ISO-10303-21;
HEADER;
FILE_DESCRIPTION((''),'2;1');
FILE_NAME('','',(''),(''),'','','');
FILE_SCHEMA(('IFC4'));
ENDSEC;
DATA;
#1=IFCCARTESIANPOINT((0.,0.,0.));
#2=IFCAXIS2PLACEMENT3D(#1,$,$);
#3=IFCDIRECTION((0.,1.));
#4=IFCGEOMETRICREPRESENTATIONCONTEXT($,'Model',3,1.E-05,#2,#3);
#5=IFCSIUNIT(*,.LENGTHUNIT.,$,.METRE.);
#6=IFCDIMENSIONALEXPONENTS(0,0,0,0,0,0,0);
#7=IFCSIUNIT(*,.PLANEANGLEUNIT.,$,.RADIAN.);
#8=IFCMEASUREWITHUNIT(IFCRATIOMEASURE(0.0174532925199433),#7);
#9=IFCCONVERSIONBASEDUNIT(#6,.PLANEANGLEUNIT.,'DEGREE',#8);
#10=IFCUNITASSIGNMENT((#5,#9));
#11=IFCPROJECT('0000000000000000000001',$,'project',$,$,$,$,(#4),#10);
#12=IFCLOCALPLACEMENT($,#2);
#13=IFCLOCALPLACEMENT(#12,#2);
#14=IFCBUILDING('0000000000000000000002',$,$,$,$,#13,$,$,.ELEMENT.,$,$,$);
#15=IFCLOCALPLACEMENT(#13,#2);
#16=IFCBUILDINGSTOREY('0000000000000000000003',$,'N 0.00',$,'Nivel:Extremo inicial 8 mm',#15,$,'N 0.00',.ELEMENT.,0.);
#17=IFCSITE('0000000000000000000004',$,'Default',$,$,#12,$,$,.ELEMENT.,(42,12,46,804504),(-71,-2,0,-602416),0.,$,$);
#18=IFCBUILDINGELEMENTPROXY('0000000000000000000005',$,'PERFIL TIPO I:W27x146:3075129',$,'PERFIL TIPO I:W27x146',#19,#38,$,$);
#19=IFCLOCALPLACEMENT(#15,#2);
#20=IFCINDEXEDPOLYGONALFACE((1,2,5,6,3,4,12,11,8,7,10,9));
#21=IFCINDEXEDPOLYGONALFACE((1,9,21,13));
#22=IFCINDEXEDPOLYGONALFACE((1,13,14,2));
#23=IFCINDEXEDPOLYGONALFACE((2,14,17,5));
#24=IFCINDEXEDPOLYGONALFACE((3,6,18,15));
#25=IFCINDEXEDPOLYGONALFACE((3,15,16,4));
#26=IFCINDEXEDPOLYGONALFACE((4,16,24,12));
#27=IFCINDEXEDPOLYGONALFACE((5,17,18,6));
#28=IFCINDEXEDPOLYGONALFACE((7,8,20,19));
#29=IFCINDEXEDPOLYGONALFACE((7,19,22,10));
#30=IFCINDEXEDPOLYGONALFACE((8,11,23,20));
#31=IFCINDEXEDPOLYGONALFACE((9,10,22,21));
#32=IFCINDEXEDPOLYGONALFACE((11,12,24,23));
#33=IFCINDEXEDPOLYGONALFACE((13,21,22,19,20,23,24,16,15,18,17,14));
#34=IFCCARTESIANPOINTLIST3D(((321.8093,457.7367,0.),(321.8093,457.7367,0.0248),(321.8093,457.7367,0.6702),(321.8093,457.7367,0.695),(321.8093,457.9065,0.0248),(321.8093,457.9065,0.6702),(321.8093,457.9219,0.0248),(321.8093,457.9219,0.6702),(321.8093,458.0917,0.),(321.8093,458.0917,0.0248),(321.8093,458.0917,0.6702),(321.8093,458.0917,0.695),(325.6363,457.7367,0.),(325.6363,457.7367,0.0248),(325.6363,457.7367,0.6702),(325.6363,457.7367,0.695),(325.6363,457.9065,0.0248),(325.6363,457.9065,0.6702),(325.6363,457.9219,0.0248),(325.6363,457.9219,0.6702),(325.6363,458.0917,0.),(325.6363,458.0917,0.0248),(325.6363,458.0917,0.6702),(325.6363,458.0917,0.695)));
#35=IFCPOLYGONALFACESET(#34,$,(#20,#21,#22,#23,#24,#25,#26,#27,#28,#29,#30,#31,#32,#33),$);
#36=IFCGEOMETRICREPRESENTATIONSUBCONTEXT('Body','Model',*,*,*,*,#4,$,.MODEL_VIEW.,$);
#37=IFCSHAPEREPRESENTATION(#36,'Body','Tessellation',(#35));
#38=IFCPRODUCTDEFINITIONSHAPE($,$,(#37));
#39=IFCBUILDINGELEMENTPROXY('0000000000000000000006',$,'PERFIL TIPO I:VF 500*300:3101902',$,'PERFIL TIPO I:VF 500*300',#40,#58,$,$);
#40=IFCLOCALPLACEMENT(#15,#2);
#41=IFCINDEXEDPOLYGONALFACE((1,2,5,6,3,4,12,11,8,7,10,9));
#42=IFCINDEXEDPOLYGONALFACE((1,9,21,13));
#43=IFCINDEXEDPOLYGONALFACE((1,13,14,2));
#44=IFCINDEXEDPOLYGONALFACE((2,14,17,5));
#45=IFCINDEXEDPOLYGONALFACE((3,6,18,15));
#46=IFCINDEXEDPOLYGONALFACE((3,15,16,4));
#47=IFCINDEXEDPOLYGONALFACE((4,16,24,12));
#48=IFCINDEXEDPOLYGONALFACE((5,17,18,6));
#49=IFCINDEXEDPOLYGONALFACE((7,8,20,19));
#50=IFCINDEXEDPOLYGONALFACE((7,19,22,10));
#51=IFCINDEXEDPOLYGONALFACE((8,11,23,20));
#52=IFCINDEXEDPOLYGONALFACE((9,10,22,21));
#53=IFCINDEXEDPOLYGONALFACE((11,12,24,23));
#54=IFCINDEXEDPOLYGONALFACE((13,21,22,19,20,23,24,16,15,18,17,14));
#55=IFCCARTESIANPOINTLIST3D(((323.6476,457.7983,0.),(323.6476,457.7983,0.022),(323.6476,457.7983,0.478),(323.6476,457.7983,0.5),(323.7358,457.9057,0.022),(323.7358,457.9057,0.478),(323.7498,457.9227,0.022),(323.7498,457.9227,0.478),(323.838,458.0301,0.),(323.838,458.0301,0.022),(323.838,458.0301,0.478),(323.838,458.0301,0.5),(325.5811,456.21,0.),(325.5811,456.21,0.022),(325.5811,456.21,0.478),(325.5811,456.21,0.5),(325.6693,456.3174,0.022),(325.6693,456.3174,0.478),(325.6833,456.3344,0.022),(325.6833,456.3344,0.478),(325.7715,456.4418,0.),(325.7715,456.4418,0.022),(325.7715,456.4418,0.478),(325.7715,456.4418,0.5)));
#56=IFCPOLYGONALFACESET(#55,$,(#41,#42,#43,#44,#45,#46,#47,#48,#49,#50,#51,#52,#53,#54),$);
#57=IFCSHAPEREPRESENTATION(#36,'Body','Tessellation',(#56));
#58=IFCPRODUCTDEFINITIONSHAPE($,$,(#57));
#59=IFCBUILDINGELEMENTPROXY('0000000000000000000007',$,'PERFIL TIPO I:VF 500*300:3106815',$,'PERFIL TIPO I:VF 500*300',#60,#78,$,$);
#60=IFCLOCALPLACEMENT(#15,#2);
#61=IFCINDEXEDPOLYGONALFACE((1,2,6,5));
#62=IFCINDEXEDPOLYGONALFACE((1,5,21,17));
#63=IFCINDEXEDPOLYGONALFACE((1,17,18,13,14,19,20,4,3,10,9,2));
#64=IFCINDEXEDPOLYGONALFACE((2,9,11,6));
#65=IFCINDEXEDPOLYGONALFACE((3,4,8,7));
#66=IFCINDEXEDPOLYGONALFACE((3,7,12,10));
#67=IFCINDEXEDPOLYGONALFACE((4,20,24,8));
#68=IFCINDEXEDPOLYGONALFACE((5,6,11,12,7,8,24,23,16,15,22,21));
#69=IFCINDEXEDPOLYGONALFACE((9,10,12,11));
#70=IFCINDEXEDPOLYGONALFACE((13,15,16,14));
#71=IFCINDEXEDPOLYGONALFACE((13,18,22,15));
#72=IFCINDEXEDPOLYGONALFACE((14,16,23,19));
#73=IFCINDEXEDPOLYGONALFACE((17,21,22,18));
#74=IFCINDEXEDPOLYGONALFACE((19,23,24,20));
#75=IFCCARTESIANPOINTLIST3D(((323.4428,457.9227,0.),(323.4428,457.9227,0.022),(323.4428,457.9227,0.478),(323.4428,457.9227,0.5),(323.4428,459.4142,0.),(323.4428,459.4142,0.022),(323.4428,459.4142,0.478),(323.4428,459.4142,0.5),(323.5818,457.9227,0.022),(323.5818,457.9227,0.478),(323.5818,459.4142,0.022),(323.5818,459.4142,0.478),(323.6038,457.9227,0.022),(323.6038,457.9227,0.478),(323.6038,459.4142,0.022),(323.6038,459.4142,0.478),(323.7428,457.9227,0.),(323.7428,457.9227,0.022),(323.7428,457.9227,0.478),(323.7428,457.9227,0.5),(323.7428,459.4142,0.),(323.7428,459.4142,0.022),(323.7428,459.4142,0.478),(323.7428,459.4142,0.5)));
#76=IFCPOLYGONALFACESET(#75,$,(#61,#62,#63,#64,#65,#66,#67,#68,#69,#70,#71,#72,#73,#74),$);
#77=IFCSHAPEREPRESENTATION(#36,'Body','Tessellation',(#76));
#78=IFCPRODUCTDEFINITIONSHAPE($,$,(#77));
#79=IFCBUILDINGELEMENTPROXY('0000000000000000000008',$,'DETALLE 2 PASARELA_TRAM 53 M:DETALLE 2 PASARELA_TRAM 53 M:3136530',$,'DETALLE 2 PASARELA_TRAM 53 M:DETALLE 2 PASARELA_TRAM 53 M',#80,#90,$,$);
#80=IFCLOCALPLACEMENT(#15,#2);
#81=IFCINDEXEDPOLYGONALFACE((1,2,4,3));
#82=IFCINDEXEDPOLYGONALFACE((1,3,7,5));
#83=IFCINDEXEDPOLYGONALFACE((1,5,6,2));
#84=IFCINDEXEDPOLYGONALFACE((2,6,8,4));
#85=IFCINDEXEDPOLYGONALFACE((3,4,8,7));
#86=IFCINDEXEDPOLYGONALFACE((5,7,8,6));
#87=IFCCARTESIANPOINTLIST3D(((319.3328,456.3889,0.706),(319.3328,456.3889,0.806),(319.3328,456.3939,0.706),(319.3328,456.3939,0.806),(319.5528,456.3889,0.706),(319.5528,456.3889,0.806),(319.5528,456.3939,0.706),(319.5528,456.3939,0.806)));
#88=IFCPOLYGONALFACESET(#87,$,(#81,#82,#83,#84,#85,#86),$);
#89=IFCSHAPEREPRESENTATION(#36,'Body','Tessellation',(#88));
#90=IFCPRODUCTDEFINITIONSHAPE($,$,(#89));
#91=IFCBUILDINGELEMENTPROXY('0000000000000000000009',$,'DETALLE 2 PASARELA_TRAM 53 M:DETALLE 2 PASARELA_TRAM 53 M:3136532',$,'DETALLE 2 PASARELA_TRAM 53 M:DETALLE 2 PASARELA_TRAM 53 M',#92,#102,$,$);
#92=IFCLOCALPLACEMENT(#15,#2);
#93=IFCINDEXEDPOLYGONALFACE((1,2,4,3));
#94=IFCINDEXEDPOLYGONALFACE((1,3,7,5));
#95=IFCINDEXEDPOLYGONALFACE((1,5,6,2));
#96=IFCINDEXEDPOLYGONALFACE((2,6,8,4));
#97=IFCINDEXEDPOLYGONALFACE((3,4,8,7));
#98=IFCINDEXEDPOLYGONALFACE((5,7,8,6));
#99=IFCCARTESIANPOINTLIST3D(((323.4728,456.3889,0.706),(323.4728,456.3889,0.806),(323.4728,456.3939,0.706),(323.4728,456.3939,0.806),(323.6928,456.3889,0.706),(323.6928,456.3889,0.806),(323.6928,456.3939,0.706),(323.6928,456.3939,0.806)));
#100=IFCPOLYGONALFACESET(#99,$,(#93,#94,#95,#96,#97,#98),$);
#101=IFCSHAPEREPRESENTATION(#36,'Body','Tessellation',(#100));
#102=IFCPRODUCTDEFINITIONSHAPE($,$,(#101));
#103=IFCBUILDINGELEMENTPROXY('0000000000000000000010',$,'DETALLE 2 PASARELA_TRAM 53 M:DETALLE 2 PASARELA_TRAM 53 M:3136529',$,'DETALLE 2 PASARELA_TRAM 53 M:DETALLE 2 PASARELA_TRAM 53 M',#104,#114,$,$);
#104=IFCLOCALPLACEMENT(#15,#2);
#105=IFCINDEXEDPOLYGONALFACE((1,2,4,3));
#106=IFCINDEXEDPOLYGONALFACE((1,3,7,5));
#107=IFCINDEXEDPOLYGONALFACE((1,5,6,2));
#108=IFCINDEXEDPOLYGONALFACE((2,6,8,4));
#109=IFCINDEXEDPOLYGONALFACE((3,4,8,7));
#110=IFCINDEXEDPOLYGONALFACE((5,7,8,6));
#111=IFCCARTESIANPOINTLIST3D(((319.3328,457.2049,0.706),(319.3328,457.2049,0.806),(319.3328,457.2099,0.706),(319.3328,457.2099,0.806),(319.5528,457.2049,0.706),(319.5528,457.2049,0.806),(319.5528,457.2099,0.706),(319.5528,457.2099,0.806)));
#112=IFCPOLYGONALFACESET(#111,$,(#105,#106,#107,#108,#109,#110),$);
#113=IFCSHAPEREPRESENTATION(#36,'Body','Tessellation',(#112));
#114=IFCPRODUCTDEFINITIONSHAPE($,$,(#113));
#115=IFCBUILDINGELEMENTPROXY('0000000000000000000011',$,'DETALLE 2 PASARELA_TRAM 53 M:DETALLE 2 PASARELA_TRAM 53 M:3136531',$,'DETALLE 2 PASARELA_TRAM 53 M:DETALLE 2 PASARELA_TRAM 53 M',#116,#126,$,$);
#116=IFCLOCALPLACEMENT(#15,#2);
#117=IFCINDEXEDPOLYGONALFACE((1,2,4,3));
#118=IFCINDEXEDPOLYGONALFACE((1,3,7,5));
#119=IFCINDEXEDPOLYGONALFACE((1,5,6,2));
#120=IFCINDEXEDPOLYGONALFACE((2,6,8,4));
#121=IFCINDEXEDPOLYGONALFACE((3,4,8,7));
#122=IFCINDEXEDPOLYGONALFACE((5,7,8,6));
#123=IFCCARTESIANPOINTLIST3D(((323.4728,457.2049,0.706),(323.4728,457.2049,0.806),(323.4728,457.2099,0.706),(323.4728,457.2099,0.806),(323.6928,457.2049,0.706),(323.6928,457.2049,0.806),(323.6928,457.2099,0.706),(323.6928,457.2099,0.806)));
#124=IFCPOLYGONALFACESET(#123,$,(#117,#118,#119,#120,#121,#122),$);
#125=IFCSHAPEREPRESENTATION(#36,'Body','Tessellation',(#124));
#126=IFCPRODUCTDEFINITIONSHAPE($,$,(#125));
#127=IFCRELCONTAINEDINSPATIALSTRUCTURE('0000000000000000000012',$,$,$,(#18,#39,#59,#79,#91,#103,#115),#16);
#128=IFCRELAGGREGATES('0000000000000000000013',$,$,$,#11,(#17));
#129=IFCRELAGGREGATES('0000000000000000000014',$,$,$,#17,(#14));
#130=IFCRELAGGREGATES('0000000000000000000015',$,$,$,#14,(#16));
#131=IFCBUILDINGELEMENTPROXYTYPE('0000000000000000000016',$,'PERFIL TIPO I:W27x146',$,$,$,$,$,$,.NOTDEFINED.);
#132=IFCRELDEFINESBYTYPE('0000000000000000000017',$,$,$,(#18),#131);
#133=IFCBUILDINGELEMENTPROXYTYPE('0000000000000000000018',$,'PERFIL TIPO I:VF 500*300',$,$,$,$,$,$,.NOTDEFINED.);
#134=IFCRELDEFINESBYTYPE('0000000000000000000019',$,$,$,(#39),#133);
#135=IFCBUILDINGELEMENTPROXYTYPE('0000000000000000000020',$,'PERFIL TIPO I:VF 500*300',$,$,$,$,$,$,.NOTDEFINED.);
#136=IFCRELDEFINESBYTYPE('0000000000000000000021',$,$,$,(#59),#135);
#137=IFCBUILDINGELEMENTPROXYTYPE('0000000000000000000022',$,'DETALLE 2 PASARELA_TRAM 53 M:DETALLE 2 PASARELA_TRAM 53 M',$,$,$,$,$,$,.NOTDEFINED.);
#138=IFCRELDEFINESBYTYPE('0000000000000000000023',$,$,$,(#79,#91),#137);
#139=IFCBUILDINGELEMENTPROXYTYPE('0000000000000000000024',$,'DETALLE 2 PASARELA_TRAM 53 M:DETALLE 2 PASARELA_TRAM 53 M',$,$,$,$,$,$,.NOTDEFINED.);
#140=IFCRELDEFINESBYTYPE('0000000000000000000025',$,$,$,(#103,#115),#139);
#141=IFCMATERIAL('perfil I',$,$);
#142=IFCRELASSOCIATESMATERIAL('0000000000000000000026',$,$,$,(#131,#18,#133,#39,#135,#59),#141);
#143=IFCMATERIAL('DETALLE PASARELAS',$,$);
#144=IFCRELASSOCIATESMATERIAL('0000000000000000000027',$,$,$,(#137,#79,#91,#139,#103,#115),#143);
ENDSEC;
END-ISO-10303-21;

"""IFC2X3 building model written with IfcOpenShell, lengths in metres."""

from ifc_helpers import new_model, entity, si_unit, converted_unit, direction, frame, frame_2d, origin, place, context, subcontext, project, spatial, polyline, rectangle, outline, extrude, source, transform, mapped, material, type_object, type_shapes, element, save


model = new_model("IFC2X3")

# Units and contexts
model_context = context("Model", 3, precision=1e-05, world=origin(), true_north=direction((0.0, 1.0)))
body_context = subcontext(model_context, "Body", "Model", "MODEL_VIEW")
ifc_project = project(units=[si_unit("LENGTHUNIT", "METRE"), converted_unit("PLANEANGLEUNIT", "DEGREE", entity("IfcRatioMeasure", 0.0174532925199433), si_unit("PLANEANGLEUNIT", "RADIAN"), dimensions=[0, 0, 0, 0, 0, 0, 0])], contexts=[model_context])

# Site, building, storey
site_placement = place(None, origin())
site = spatial("IfcSite", under=ifc_project, at=site_placement, Name="Default", CompositionType="ELEMENT", RefLatitude=(42, 12, 46, 804504), RefLongitude=(-71, -2, 0, -602416), RefElevation=0.0)
building_placement = place(site_placement, origin())
building = spatial("IfcBuilding", under=site, at=building_placement, CompositionType="ELEMENT")
storey_placement = place(building_placement, origin())
storey = spatial("IfcBuildingStorey", under=building, at=storey_placement, Name="N 0.00", ObjectType="Nivel:Extremo inicial 8 mm", LongName="N 0.00", CompositionType="ELEMENT", Elevation=0.0)

# Building element proxies
ifc_material_1 = material(Name="perfil I")
building_element_proxy_type_1 = type_object("IfcBuildingElementProxyType", Name="PERFIL TIPO I:W27x146", PredefinedType="NOTDEFINED", material=ifc_material_1)
shared_shape_1 = source(origin(), body_context, "Body", "SweptSolid", [
    extrude(outline(polyline([(0.3227, -0.1775), (0.3475, -0.1775), (0.3475, 0.1775), (0.3227, 0.1775), (0.3227, 0.0077), (-0.3227, 0.0077), (-0.3227, 0.1775), (-0.3475, 0.1775), (-0.3475, -0.1775), (-0.3227, -0.1775), (-0.3227, -0.0077), (0.3227, -0.0077), (0.3227, -0.1775)])), frame((0.0, 0.0, 0.3475), z_axis=(1.0, 0.0, 0.0), x_axis=(0.0, 0.0, 1.0)), (0.0, 0.0, 1.0), 3.827),
])
type_shapes(building_element_proxy_type_1, [shared_shape_1])
proxy_1_placement = place(storey_placement, frame((321.8093, 457.9142, 0.0)))
element("IfcBuildingElementProxy", 1, at=proxy_1_placement, inside=storey, type_object=building_element_proxy_type_1, material=ifc_material_1, Name="PERFIL TIPO I:W27x146:3075129", ObjectType="PERFIL TIPO I:W27x146", context=body_context, shape_type="MappedRepresentation", body=[
    mapped(shared_shape_1, transform((0.0, 0.0, 0.0), scale=1.0)),
])
building_element_proxy_type_2 = type_object("IfcBuildingElementProxyType", Name="PERFIL TIPO I:VF 500*300", PredefinedType="NOTDEFINED", material=ifc_material_1)
shared_shape_2 = source(origin(), body_context, "Body", "SweptSolid", [
    extrude(outline(polyline([(-0.15, -0.228), (-0.15, -0.25), (0.15, -0.25), (0.15, -0.228), (0.011, -0.228), (0.011, 0.228), (0.15, 0.228), (0.15, 0.25), (-0.15, 0.25), (-0.15, 0.228), (-0.011, 0.228), (-0.011, -0.228), (-0.15, -0.228)])), frame((0.0, 0.0, 0.25), z_axis=(-1.0, 0.0, 0.0), x_axis=(0.0, 1.0, 0.0)), (0.0, 0.0, -1.0), 2.5022),
])
type_shapes(building_element_proxy_type_2, [shared_shape_2])
proxy_2_placement = place(storey_placement, frame((323.7428, 457.9142, 0.0), z_axis=(0.0, 0.0, 1.0), x_axis=(0.772718, -0.63475, 0.0)))
element("IfcBuildingElementProxy", 2, at=proxy_2_placement, inside=storey, type_object=building_element_proxy_type_2, material=ifc_material_1, Name="PERFIL TIPO I:VF 500*300:3101902", ObjectType="PERFIL TIPO I:VF 500*300", context=body_context, shape_type="MappedRepresentation", body=[
    mapped(shared_shape_2, transform((0.0, 0.0, 0.0), scale=1.0)),
])
building_element_proxy_type_3 = type_object("IfcBuildingElementProxyType", Name="PERFIL TIPO I:VF 500*300", PredefinedType="NOTDEFINED", material=ifc_material_1)
shared_shape_3 = source(origin(), body_context, "Body", "SweptSolid", [
    extrude(outline(polyline([(-0.15, -0.228), (-0.15, -0.25), (0.15, -0.25), (0.15, -0.228), (0.011, -0.228), (0.011, 0.228), (0.15, 0.228), (0.15, 0.25), (-0.15, 0.25), (-0.15, 0.228), (-0.011, 0.228), (-0.011, -0.228), (-0.15, -0.228)])), frame((0.0, 0.0, 0.25), z_axis=(-1.0, 0.0, 0.0), x_axis=(0.0, 1.0, 0.0)), (0.0, 0.0, -1.0), 1.4915),
])
type_shapes(building_element_proxy_type_3, [shared_shape_3])
proxy_3_placement = place(storey_placement, frame((323.5928, 457.9227, 0.0), z_axis=(0.0, 0.0, 1.0), x_axis=(0.0, 1.0, 0.0)))
element("IfcBuildingElementProxy", 3, at=proxy_3_placement, inside=storey, type_object=building_element_proxy_type_3, material=ifc_material_1, Name="PERFIL TIPO I:VF 500*300:3106815", ObjectType="PERFIL TIPO I:VF 500*300", context=body_context, shape_type="MappedRepresentation", body=[
    mapped(shared_shape_3, transform((0.0, 0.0, 0.0), scale=1.0)),
])
ifc_material_2 = material(Name="DETALLE PASARELAS")
building_element_proxy_type_4 = type_object("IfcBuildingElementProxyType", Name="DETALLE 2 PASARELA_TRAM 53 M:DETALLE 2 PASARELA_TRAM 53 M", PredefinedType="NOTDEFINED", material=ifc_material_2)
shared_shape_4 = source(origin(), body_context, "Body", "SweptSolid", [
    extrude(rectangle(XDim=0.22, YDim=0.005, at=frame_2d((0.0, 0.0), x_axis=(1.0, 0.0))), frame((0.11, 0.0475, 0.0), z_axis=(0.0, 0.0, 1.0), x_axis=(-1.0, 0.0, 0.0)), (0.0, 0.0, 1.0), 0.1),
])
type_shapes(building_element_proxy_type_4, [shared_shape_4])
for number, where, name in (
    (4, (319.3328, 456.3439, 0.706), "DETALLE 2 PASARELA_TRAM 53 M:DETALLE 2 PASARELA_TRAM 53 M:3136530"),
    (5, (323.4728, 456.3439, 0.706), "DETALLE 2 PASARELA_TRAM 53 M:DETALLE 2 PASARELA_TRAM 53 M:3136532"),
):
    element("IfcBuildingElementProxy", number, at=place(storey_placement, frame(where)), inside=storey, type_object=building_element_proxy_type_4, material=ifc_material_2, Name=name, ObjectType="DETALLE 2 PASARELA_TRAM 53 M:DETALLE 2 PASARELA_TRAM 53 M", context=body_context, shape_type="MappedRepresentation", body=[
        mapped(shared_shape_4, transform((0.0, 0.0, 0.0), scale=1.0)),
    ])
building_element_proxy_type_5 = type_object("IfcBuildingElementProxyType", Name="DETALLE 2 PASARELA_TRAM 53 M:DETALLE 2 PASARELA_TRAM 53 M", PredefinedType="NOTDEFINED", material=ifc_material_2)
shared_shape_5 = source(origin(), body_context, "Body", "SweptSolid", [
    extrude(rectangle(XDim=0.005, YDim=0.22, at=frame_2d((0.0, 0.0), x_axis=(1.0, 0.0))), frame((0.11, -0.0475, 0.0), z_axis=(0.0, 0.0, 1.0), x_axis=(0.0, 1.0, 0.0)), (0.0, 0.0, 1.0), 0.1),
])
type_shapes(building_element_proxy_type_5, [shared_shape_5])
for number, where, name in (
    (6, (319.3328, 457.2549, 0.706), "DETALLE 2 PASARELA_TRAM 53 M:DETALLE 2 PASARELA_TRAM 53 M:3136529"),
    (7, (323.4728, 457.2549, 0.706), "DETALLE 2 PASARELA_TRAM 53 M:DETALLE 2 PASARELA_TRAM 53 M:3136531"),
):
    element("IfcBuildingElementProxy", number, at=place(storey_placement, frame(where)), inside=storey, type_object=building_element_proxy_type_5, material=ifc_material_2, Name=name, ObjectType="DETALLE 2 PASARELA_TRAM 53 M:DETALLE 2 PASARELA_TRAM 53 M", context=body_context, shape_type="MappedRepresentation", body=[
        mapped(shared_shape_5, transform((0.0, 0.0, 0.0), scale=1.0)),
    ])

save(model, "model.ifc")
